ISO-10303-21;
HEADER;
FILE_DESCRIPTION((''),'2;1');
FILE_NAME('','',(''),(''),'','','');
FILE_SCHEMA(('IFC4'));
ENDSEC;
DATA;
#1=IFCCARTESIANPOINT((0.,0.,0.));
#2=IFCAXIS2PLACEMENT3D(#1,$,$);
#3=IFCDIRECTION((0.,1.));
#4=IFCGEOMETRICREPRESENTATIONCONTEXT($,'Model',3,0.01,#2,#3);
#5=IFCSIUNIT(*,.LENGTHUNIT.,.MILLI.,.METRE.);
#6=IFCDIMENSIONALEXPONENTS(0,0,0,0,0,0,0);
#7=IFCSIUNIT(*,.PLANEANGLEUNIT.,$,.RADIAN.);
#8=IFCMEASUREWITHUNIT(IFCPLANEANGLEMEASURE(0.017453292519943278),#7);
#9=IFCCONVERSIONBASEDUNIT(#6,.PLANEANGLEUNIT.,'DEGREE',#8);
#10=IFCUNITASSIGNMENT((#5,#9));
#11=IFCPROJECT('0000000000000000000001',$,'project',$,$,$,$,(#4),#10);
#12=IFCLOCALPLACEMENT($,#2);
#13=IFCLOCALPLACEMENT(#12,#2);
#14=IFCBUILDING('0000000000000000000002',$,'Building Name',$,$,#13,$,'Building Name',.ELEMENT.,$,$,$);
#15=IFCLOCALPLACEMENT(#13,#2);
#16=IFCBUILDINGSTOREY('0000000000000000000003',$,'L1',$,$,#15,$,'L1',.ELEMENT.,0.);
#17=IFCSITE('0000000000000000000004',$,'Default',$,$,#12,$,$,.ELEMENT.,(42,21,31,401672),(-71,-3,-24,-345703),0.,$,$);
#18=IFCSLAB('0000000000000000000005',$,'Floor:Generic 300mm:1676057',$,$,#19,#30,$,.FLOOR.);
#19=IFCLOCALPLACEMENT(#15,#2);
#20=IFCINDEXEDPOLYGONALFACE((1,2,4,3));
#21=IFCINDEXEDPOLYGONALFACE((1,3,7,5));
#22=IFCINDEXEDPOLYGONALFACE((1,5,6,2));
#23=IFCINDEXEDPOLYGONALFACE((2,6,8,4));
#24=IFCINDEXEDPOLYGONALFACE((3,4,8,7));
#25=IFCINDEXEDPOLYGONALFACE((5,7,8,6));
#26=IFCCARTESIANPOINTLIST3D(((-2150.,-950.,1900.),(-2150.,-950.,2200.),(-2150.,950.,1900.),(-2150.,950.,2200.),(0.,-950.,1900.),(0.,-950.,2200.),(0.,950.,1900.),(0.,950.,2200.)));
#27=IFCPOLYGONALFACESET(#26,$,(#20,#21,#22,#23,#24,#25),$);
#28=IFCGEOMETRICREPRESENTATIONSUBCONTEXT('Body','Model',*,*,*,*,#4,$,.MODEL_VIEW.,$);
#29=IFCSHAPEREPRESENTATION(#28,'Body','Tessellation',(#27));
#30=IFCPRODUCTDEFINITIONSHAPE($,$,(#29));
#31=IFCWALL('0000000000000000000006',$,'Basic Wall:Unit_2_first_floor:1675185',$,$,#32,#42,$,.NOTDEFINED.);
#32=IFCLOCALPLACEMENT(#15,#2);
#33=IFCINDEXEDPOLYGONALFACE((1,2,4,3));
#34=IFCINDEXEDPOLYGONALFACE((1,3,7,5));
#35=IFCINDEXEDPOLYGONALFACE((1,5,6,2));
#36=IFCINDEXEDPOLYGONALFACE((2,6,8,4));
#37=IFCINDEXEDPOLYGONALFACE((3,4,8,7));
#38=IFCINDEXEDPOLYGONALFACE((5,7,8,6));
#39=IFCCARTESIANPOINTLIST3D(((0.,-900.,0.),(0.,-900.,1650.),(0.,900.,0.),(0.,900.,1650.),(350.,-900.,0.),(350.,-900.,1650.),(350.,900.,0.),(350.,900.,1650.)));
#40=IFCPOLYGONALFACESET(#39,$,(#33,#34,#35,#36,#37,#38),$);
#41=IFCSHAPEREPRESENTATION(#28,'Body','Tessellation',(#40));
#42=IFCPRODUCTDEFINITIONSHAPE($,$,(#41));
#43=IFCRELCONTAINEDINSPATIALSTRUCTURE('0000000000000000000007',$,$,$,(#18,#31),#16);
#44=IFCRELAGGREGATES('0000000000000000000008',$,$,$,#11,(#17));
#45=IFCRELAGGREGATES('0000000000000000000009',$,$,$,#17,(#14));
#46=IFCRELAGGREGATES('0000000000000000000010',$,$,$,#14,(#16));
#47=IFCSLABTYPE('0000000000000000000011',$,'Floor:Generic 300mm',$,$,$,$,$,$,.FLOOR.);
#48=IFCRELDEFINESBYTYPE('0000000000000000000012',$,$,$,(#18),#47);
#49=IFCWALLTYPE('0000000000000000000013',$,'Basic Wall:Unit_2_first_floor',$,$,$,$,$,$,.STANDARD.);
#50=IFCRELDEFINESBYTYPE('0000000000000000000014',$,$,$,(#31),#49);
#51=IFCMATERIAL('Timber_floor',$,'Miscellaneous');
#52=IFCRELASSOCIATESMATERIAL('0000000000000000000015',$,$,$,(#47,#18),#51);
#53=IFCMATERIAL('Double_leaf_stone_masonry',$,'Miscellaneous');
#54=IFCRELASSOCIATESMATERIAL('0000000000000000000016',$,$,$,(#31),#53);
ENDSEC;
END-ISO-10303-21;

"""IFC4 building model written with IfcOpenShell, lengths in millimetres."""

from ifc_helpers import new_model, entity, si_unit, converted_unit, direction, frame, origin, place, context, subcontext, project, spatial, indexed_curve, outline, extrude, material, type_object, element, save


model = new_model("IFC4")

# Units and contexts
model_context = context("Model", 3, precision=0.01, world=origin(), true_north=direction((0.0, 1.0)))
body_context = subcontext(model_context, "Body", "Model", "MODEL_VIEW")
ifc_project = project(units=[si_unit("LENGTHUNIT", "METRE", prefix="MILLI"), converted_unit("PLANEANGLEUNIT", "DEGREE", entity("IfcPlaneAngleMeasure", 0.017453292519943278), si_unit("PLANEANGLEUNIT", "RADIAN"), dimensions=[0, 0, 0, 0, 0, 0, 0])], contexts=[model_context])

# Site, building, storey
site_placement = place(None, origin())
site = spatial("IfcSite", under=ifc_project, at=site_placement, Name="Default", CompositionType="ELEMENT", RefLatitude=(42, 21, 31, 401672), RefLongitude=(-71, -3, -24, -345703), RefElevation=0.0)
building_placement = place(site_placement, origin())
building = spatial("IfcBuilding", under=site, at=building_placement, Name="Building Name", LongName="Building Name", CompositionType="ELEMENT")
storey_placement = place(building_placement, origin())
storey = spatial("IfcBuildingStorey", under=building, at=storey_placement, Name="L1", LongName="L1", CompositionType="ELEMENT", Elevation=0.0)

# Slab
ifc_material_1 = material(Name="Timber_floor", Category="Miscellaneous")
slab_type = type_object("IfcSlabType", Name="Floor:Generic 300mm", PredefinedType="FLOOR", material=ifc_material_1)
slab_placement = place(storey_placement, origin())
element("IfcSlab", 1, at=slab_placement, inside=storey, type_object=slab_type, material=ifc_material_1, Name="Floor:Generic 300mm:1676057", PredefinedType="FLOOR", context=body_context, shape_type="SweptSolid", body=[
    extrude(outline(indexed_curve([(-950.0, -1075.0), (950.0, -1075.0), (950.0, 1075.0), (-950.0, 1075.0), (-950.0, -1075.0)], self_intersect=False)), frame((-1075.0, 0.0, 2200.0), z_axis=(0.0, 0.0, -1.0), x_axis=(0.0, 1.0, 0.0)), (0.0, 0.0, 1.0), 300.0),
])

# Wall
ifc_material_2 = material(Name="Double_leaf_stone_masonry", Category="Miscellaneous")
wall_type = type_object("IfcWallType", Name="Basic Wall:Unit_2_first_floor", PredefinedType="STANDARD")
wall_placement = place(storey_placement, frame((175.0, -900.0, 0.0), z_axis=(0.0, 0.0, 1.0), x_axis=(0.0, 1.0, 0.0)))
element("IfcWall", 2, at=wall_placement, inside=storey, type_object=wall_type, material=ifc_material_2, Name="Basic Wall:Unit_2_first_floor:1675185", PredefinedType="NOTDEFINED", context=body_context, shape_type="SweptSolid", body=[
    extrude(outline(indexed_curve([(1800.0, 175.0), (0.0, 175.0), (0.0, -175.0), (1800.0, -175.0), (1800.0, 175.0)], self_intersect=False)), origin(), (0.0, 0.0, 1.0), 1650.0),
])

save(model, "model.ifc")
